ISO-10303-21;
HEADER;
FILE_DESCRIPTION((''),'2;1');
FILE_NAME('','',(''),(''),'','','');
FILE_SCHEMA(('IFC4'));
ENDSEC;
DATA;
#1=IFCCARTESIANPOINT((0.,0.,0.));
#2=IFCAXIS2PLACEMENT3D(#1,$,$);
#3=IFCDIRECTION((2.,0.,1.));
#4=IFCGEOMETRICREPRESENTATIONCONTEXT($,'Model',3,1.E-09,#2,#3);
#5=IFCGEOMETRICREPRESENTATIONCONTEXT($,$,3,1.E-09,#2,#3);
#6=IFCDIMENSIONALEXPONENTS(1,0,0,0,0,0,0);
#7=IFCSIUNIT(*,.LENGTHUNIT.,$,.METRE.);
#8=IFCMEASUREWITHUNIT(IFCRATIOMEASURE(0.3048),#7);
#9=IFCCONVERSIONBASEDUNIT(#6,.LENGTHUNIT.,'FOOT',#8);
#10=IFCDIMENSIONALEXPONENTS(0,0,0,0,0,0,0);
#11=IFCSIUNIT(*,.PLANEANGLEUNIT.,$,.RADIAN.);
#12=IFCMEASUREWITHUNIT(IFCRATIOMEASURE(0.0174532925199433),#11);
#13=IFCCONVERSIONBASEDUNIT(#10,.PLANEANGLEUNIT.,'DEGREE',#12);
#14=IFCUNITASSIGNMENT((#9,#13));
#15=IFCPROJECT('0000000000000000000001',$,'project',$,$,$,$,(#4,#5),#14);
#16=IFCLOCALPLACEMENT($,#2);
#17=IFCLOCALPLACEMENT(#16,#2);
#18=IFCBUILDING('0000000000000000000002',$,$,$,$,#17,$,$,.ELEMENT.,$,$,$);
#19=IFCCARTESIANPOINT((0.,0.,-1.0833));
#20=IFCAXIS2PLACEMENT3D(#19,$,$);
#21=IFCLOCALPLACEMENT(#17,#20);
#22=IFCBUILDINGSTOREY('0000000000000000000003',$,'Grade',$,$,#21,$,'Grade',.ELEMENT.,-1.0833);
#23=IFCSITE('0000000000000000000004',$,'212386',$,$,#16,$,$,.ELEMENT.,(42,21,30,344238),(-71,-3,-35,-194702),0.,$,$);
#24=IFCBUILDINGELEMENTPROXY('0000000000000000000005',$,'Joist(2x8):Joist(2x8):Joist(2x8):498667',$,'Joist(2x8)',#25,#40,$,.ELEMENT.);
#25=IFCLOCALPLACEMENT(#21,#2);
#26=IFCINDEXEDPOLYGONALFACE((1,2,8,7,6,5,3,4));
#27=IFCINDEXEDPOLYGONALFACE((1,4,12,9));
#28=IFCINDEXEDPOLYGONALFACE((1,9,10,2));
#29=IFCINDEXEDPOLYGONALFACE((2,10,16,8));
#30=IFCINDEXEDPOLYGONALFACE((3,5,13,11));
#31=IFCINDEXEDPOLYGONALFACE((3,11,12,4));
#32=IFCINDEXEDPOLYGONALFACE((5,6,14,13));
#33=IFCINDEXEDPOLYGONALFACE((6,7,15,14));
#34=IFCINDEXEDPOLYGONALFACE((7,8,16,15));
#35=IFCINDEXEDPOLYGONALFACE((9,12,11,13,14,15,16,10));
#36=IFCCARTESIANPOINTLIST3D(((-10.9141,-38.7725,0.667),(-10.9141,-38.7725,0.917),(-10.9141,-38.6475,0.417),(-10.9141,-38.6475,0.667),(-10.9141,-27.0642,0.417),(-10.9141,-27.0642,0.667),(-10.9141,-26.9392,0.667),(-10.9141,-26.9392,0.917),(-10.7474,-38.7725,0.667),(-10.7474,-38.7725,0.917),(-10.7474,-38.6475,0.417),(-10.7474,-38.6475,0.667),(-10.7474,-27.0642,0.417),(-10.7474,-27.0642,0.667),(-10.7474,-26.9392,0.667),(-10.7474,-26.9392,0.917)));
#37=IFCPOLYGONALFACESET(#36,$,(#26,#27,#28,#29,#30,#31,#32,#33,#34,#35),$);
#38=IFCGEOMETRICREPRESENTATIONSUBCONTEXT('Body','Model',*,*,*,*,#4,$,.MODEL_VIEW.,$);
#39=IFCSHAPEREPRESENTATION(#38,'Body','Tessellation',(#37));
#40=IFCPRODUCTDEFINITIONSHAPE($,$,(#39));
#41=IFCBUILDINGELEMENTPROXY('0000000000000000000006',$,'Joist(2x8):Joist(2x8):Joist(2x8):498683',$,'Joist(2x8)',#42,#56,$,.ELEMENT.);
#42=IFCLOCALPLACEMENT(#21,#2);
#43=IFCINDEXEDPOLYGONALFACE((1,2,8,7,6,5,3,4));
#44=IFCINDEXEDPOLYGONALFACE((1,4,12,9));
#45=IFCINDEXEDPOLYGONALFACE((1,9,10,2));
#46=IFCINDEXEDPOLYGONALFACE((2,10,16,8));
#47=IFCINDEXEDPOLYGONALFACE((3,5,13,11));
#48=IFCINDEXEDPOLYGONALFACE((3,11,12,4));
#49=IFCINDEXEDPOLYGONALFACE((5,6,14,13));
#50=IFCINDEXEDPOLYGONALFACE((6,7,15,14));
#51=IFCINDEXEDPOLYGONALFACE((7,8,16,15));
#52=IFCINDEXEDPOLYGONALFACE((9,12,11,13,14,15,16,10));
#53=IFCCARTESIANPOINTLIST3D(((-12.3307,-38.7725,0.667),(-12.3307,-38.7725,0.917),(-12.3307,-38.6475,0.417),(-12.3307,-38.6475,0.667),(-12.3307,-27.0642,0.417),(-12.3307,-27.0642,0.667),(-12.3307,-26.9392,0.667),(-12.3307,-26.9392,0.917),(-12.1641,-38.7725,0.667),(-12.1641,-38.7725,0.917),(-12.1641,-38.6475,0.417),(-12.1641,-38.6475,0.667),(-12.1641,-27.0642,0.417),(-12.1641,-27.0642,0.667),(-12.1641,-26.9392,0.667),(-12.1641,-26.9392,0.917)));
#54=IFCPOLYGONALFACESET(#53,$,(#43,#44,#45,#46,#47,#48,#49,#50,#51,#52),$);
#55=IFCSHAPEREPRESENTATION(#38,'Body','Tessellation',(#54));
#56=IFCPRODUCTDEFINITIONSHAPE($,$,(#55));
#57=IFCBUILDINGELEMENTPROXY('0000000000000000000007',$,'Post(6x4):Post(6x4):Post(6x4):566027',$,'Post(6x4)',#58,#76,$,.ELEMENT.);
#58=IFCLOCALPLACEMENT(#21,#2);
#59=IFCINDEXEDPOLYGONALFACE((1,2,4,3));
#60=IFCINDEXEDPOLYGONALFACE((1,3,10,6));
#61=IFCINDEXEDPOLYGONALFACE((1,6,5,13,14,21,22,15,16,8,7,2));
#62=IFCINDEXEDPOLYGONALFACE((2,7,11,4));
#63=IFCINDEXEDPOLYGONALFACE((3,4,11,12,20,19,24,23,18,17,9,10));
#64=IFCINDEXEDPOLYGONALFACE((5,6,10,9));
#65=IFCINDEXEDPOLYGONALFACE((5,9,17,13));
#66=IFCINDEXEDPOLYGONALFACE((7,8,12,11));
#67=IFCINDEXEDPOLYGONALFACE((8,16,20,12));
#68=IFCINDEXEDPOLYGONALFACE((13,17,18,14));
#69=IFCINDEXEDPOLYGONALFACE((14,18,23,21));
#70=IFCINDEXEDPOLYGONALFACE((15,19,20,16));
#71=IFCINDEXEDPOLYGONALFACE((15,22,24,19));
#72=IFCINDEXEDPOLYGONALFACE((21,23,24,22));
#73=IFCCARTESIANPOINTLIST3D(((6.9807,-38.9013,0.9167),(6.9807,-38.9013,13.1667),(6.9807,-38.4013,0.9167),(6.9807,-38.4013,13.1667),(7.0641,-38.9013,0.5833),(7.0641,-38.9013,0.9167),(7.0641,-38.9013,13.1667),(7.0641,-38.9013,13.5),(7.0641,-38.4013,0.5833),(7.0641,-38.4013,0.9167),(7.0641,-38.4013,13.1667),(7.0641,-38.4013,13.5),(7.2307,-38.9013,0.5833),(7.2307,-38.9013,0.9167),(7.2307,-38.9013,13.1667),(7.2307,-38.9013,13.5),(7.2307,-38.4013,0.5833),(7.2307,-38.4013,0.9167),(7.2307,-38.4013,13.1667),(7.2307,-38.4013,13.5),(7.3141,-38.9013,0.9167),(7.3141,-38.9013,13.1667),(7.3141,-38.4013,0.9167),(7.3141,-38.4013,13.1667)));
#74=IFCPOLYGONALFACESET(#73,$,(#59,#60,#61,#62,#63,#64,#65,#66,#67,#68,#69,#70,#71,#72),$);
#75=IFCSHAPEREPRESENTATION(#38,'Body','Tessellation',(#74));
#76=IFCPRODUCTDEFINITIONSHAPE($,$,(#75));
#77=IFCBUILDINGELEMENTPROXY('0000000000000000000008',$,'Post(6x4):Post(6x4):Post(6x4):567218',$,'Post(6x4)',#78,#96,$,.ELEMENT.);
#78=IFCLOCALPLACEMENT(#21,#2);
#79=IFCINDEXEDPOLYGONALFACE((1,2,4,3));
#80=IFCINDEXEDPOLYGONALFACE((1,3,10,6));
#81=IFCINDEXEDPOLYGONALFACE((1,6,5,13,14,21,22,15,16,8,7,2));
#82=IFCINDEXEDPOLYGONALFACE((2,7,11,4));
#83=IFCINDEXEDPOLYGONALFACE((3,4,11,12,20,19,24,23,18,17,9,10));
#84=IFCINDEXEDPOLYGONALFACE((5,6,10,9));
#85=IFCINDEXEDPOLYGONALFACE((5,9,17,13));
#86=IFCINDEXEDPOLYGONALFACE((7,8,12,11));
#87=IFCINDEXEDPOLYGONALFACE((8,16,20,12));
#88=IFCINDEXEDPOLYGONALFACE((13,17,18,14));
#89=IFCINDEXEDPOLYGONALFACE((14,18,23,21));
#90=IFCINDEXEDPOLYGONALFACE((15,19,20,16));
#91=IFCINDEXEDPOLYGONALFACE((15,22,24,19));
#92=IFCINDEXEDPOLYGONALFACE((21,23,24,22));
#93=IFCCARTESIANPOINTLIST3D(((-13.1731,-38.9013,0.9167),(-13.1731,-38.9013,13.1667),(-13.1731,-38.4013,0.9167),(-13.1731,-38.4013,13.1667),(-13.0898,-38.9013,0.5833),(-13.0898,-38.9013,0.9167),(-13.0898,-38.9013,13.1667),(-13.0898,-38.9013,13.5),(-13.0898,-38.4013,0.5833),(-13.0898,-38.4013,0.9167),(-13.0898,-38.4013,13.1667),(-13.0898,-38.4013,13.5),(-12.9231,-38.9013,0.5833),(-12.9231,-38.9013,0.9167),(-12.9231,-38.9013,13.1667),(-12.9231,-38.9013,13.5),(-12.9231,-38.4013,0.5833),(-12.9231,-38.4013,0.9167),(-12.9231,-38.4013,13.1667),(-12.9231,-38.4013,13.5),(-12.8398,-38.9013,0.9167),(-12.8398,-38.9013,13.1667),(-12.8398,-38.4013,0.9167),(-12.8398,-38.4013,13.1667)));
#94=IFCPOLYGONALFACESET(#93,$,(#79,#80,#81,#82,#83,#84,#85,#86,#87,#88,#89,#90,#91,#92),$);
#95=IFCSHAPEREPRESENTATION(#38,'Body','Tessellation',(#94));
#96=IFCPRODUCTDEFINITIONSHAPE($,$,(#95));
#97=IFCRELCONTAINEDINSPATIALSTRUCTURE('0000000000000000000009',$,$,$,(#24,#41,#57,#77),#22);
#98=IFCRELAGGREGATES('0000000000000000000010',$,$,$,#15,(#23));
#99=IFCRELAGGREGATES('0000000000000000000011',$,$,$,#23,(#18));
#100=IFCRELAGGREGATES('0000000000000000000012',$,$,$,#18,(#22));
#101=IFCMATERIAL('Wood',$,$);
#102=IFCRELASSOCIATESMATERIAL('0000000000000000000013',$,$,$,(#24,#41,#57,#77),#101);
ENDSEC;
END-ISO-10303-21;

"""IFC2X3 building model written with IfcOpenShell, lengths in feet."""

from ifc_helpers import new_model, entity, si_unit, converted_unit, direction, frame, origin, place, context, subcontext, project, spatial, polyline, outline, extrude, source, transform, mapped, material, element, save


model = new_model("IFC2X3")

# Units and contexts
model_context = context("Model", 3, precision=1e-09, world=origin(), true_north=direction((2.0, 0.0, 1.0)))
context_of_model = context(None, 3, precision=1e-09, world=origin(), true_north=direction((2.0, 0.0, 1.0)))
body_context = subcontext(model_context, "Body", "Model", "MODEL_VIEW")
ifc_project = project(units=[converted_unit("LENGTHUNIT", "FOOT", entity("IfcRatioMeasure", 0.3048), si_unit("LENGTHUNIT", "METRE"), dimensions=[1, 0, 0, 0, 0, 0, 0]), converted_unit("PLANEANGLEUNIT", "DEGREE", entity("IfcRatioMeasure", 0.0174532925199433), si_unit("PLANEANGLEUNIT", "RADIAN"), dimensions=[0, 0, 0, 0, 0, 0, 0])], contexts=[model_context, context_of_model])

# Site, building, storey
site_placement = place(None, origin())
site = spatial("IfcSite", under=ifc_project, at=site_placement, Name="212386", CompositionType="ELEMENT", RefLatitude=(42, 21, 30, 344238), RefLongitude=(-71, -3, -35, -194702), RefElevation=0.0)
building_placement = place(site_placement, origin())
building = spatial("IfcBuilding", under=site, at=building_placement, CompositionType="ELEMENT")
storey_placement = place(building_placement, frame((0.0, 0.0, -1.0833)))
storey = spatial("IfcBuildingStorey", under=building, at=storey_placement, Name="Grade", LongName="Grade", CompositionType="ELEMENT", Elevation=-1.0833)

# Building element proxies
ifc_material_1 = material(Name="Wood")
shared_shape_1 = source(origin(), body_context, "Body", "SweptSolid", [
    extrude(outline(polyline([(-0.25, -5.9167), (0.0, -5.9167), (0.0, -5.7917), (0.25, -5.7917), (0.25, 5.7917), (0.0, 5.7917), (0.0, 5.9167), (-0.25, 5.9167), (-0.25, -5.9167)])), frame((-10.9141, -32.8558, -0.4164), z_axis=(1.0, 0.0, 0.0), x_axis=(0.0, 0.0, -1.0)), (0.0, 0.0, 1.0), 0.1667),
])
proxy_1_placement = place(storey_placement, frame((0.0, 0.0, 1.0833)))
element("IfcBuildingElementProxy", 1, at=proxy_1_placement, inside=storey, material=ifc_material_1, Name="Joist(2x8):Joist(2x8):Joist(2x8):498667", ObjectType="Joist(2x8)", CompositionType="ELEMENT", context=body_context, shape_type="MappedRepresentation", body=[
    mapped(shared_shape_1, transform((0.0, 0.0, 0.0), scale=1.0)),
])
shared_shape_2 = source(origin(), body_context, "Body", "SweptSolid", [
    extrude(outline(polyline([(-0.25, -5.9167), (0.0, -5.9167), (0.0, -5.7917), (0.25, -5.7917), (0.25, 5.7917), (0.0, 5.7917), (0.0, 5.9167), (-0.25, 5.9167), (-0.25, -5.9167)])), frame((-12.3307, -32.8558, -0.4164), z_axis=(1.0, 0.0, 0.0), x_axis=(0.0, 0.0, -1.0)), (0.0, 0.0, 1.0), 0.1667),
])
proxy_2_placement = place(storey_placement, frame((0.0, 0.0, 1.0833)))
element("IfcBuildingElementProxy", 2, at=proxy_2_placement, inside=storey, material=ifc_material_1, Name="Joist(2x8):Joist(2x8):Joist(2x8):498683", ObjectType="Joist(2x8)", CompositionType="ELEMENT", context=body_context, shape_type="MappedRepresentation", body=[
    mapped(shared_shape_2, transform((0.0, 0.0, 0.0), scale=1.0)),
])
shared_shape_3 = source(origin(), body_context, "Body", "SweptSolid", [
    extrude(outline(polyline([(-6.4583, 0.0833), (-6.4583, -0.0833), (-6.125, -0.0833), (-6.125, -0.1667), (6.125, -0.1667), (6.125, -0.0833), (6.4583, -0.0833), (6.4583, 0.0833), (6.125, 0.0833), (6.125, 0.1667), (-6.125, 0.1667), (-6.125, 0.0833), (-6.4583, 0.0833)])), frame((7.1474, -38.9013, 5.9583), z_axis=(0.0, -1.0, 0.0), x_axis=(0.0, 0.0, -1.0)), (0.0, 0.0, -1.0), 0.5),
])
proxy_3_placement = place(storey_placement, frame((0.0, 0.0, 1.0833)))
element("IfcBuildingElementProxy", 3, at=proxy_3_placement, inside=storey, material=ifc_material_1, Name="Post(6x4):Post(6x4):Post(6x4):566027", ObjectType="Post(6x4)", CompositionType="ELEMENT", context=body_context, shape_type="MappedRepresentation", body=[
    mapped(shared_shape_3, transform((0.0, 0.0, 0.0), scale=1.0)),
])
shared_shape_4 = source(origin(), body_context, "Body", "SweptSolid", [
    extrude(outline(polyline([(-6.4583, 0.0833), (-6.4583, -0.0833), (-6.125, -0.0833), (-6.125, -0.1667), (6.125, -0.1667), (6.125, -0.0833), (6.4583, -0.0833), (6.4583, 0.0833), (6.125, 0.0833), (6.125, 0.1667), (-6.125, 0.1667), (-6.125, 0.0833), (-6.4583, 0.0833)])), frame((-13.0064, -38.9013, 5.9583), z_axis=(0.0, -1.0, 0.0), x_axis=(0.0, 0.0, -1.0)), (0.0, 0.0, -1.0), 0.5),
])
proxy_4_placement = place(storey_placement, frame((0.0, 0.0, 1.0833)))
element("IfcBuildingElementProxy", 4, at=proxy_4_placement, inside=storey, material=ifc_material_1, Name="Post(6x4):Post(6x4):Post(6x4):567218", ObjectType="Post(6x4)", CompositionType="ELEMENT", context=body_context, shape_type="MappedRepresentation", body=[
    mapped(shared_shape_4, transform((0.0, 0.0, 0.0), scale=1.0)),
])

save(model, "model.ifc")
